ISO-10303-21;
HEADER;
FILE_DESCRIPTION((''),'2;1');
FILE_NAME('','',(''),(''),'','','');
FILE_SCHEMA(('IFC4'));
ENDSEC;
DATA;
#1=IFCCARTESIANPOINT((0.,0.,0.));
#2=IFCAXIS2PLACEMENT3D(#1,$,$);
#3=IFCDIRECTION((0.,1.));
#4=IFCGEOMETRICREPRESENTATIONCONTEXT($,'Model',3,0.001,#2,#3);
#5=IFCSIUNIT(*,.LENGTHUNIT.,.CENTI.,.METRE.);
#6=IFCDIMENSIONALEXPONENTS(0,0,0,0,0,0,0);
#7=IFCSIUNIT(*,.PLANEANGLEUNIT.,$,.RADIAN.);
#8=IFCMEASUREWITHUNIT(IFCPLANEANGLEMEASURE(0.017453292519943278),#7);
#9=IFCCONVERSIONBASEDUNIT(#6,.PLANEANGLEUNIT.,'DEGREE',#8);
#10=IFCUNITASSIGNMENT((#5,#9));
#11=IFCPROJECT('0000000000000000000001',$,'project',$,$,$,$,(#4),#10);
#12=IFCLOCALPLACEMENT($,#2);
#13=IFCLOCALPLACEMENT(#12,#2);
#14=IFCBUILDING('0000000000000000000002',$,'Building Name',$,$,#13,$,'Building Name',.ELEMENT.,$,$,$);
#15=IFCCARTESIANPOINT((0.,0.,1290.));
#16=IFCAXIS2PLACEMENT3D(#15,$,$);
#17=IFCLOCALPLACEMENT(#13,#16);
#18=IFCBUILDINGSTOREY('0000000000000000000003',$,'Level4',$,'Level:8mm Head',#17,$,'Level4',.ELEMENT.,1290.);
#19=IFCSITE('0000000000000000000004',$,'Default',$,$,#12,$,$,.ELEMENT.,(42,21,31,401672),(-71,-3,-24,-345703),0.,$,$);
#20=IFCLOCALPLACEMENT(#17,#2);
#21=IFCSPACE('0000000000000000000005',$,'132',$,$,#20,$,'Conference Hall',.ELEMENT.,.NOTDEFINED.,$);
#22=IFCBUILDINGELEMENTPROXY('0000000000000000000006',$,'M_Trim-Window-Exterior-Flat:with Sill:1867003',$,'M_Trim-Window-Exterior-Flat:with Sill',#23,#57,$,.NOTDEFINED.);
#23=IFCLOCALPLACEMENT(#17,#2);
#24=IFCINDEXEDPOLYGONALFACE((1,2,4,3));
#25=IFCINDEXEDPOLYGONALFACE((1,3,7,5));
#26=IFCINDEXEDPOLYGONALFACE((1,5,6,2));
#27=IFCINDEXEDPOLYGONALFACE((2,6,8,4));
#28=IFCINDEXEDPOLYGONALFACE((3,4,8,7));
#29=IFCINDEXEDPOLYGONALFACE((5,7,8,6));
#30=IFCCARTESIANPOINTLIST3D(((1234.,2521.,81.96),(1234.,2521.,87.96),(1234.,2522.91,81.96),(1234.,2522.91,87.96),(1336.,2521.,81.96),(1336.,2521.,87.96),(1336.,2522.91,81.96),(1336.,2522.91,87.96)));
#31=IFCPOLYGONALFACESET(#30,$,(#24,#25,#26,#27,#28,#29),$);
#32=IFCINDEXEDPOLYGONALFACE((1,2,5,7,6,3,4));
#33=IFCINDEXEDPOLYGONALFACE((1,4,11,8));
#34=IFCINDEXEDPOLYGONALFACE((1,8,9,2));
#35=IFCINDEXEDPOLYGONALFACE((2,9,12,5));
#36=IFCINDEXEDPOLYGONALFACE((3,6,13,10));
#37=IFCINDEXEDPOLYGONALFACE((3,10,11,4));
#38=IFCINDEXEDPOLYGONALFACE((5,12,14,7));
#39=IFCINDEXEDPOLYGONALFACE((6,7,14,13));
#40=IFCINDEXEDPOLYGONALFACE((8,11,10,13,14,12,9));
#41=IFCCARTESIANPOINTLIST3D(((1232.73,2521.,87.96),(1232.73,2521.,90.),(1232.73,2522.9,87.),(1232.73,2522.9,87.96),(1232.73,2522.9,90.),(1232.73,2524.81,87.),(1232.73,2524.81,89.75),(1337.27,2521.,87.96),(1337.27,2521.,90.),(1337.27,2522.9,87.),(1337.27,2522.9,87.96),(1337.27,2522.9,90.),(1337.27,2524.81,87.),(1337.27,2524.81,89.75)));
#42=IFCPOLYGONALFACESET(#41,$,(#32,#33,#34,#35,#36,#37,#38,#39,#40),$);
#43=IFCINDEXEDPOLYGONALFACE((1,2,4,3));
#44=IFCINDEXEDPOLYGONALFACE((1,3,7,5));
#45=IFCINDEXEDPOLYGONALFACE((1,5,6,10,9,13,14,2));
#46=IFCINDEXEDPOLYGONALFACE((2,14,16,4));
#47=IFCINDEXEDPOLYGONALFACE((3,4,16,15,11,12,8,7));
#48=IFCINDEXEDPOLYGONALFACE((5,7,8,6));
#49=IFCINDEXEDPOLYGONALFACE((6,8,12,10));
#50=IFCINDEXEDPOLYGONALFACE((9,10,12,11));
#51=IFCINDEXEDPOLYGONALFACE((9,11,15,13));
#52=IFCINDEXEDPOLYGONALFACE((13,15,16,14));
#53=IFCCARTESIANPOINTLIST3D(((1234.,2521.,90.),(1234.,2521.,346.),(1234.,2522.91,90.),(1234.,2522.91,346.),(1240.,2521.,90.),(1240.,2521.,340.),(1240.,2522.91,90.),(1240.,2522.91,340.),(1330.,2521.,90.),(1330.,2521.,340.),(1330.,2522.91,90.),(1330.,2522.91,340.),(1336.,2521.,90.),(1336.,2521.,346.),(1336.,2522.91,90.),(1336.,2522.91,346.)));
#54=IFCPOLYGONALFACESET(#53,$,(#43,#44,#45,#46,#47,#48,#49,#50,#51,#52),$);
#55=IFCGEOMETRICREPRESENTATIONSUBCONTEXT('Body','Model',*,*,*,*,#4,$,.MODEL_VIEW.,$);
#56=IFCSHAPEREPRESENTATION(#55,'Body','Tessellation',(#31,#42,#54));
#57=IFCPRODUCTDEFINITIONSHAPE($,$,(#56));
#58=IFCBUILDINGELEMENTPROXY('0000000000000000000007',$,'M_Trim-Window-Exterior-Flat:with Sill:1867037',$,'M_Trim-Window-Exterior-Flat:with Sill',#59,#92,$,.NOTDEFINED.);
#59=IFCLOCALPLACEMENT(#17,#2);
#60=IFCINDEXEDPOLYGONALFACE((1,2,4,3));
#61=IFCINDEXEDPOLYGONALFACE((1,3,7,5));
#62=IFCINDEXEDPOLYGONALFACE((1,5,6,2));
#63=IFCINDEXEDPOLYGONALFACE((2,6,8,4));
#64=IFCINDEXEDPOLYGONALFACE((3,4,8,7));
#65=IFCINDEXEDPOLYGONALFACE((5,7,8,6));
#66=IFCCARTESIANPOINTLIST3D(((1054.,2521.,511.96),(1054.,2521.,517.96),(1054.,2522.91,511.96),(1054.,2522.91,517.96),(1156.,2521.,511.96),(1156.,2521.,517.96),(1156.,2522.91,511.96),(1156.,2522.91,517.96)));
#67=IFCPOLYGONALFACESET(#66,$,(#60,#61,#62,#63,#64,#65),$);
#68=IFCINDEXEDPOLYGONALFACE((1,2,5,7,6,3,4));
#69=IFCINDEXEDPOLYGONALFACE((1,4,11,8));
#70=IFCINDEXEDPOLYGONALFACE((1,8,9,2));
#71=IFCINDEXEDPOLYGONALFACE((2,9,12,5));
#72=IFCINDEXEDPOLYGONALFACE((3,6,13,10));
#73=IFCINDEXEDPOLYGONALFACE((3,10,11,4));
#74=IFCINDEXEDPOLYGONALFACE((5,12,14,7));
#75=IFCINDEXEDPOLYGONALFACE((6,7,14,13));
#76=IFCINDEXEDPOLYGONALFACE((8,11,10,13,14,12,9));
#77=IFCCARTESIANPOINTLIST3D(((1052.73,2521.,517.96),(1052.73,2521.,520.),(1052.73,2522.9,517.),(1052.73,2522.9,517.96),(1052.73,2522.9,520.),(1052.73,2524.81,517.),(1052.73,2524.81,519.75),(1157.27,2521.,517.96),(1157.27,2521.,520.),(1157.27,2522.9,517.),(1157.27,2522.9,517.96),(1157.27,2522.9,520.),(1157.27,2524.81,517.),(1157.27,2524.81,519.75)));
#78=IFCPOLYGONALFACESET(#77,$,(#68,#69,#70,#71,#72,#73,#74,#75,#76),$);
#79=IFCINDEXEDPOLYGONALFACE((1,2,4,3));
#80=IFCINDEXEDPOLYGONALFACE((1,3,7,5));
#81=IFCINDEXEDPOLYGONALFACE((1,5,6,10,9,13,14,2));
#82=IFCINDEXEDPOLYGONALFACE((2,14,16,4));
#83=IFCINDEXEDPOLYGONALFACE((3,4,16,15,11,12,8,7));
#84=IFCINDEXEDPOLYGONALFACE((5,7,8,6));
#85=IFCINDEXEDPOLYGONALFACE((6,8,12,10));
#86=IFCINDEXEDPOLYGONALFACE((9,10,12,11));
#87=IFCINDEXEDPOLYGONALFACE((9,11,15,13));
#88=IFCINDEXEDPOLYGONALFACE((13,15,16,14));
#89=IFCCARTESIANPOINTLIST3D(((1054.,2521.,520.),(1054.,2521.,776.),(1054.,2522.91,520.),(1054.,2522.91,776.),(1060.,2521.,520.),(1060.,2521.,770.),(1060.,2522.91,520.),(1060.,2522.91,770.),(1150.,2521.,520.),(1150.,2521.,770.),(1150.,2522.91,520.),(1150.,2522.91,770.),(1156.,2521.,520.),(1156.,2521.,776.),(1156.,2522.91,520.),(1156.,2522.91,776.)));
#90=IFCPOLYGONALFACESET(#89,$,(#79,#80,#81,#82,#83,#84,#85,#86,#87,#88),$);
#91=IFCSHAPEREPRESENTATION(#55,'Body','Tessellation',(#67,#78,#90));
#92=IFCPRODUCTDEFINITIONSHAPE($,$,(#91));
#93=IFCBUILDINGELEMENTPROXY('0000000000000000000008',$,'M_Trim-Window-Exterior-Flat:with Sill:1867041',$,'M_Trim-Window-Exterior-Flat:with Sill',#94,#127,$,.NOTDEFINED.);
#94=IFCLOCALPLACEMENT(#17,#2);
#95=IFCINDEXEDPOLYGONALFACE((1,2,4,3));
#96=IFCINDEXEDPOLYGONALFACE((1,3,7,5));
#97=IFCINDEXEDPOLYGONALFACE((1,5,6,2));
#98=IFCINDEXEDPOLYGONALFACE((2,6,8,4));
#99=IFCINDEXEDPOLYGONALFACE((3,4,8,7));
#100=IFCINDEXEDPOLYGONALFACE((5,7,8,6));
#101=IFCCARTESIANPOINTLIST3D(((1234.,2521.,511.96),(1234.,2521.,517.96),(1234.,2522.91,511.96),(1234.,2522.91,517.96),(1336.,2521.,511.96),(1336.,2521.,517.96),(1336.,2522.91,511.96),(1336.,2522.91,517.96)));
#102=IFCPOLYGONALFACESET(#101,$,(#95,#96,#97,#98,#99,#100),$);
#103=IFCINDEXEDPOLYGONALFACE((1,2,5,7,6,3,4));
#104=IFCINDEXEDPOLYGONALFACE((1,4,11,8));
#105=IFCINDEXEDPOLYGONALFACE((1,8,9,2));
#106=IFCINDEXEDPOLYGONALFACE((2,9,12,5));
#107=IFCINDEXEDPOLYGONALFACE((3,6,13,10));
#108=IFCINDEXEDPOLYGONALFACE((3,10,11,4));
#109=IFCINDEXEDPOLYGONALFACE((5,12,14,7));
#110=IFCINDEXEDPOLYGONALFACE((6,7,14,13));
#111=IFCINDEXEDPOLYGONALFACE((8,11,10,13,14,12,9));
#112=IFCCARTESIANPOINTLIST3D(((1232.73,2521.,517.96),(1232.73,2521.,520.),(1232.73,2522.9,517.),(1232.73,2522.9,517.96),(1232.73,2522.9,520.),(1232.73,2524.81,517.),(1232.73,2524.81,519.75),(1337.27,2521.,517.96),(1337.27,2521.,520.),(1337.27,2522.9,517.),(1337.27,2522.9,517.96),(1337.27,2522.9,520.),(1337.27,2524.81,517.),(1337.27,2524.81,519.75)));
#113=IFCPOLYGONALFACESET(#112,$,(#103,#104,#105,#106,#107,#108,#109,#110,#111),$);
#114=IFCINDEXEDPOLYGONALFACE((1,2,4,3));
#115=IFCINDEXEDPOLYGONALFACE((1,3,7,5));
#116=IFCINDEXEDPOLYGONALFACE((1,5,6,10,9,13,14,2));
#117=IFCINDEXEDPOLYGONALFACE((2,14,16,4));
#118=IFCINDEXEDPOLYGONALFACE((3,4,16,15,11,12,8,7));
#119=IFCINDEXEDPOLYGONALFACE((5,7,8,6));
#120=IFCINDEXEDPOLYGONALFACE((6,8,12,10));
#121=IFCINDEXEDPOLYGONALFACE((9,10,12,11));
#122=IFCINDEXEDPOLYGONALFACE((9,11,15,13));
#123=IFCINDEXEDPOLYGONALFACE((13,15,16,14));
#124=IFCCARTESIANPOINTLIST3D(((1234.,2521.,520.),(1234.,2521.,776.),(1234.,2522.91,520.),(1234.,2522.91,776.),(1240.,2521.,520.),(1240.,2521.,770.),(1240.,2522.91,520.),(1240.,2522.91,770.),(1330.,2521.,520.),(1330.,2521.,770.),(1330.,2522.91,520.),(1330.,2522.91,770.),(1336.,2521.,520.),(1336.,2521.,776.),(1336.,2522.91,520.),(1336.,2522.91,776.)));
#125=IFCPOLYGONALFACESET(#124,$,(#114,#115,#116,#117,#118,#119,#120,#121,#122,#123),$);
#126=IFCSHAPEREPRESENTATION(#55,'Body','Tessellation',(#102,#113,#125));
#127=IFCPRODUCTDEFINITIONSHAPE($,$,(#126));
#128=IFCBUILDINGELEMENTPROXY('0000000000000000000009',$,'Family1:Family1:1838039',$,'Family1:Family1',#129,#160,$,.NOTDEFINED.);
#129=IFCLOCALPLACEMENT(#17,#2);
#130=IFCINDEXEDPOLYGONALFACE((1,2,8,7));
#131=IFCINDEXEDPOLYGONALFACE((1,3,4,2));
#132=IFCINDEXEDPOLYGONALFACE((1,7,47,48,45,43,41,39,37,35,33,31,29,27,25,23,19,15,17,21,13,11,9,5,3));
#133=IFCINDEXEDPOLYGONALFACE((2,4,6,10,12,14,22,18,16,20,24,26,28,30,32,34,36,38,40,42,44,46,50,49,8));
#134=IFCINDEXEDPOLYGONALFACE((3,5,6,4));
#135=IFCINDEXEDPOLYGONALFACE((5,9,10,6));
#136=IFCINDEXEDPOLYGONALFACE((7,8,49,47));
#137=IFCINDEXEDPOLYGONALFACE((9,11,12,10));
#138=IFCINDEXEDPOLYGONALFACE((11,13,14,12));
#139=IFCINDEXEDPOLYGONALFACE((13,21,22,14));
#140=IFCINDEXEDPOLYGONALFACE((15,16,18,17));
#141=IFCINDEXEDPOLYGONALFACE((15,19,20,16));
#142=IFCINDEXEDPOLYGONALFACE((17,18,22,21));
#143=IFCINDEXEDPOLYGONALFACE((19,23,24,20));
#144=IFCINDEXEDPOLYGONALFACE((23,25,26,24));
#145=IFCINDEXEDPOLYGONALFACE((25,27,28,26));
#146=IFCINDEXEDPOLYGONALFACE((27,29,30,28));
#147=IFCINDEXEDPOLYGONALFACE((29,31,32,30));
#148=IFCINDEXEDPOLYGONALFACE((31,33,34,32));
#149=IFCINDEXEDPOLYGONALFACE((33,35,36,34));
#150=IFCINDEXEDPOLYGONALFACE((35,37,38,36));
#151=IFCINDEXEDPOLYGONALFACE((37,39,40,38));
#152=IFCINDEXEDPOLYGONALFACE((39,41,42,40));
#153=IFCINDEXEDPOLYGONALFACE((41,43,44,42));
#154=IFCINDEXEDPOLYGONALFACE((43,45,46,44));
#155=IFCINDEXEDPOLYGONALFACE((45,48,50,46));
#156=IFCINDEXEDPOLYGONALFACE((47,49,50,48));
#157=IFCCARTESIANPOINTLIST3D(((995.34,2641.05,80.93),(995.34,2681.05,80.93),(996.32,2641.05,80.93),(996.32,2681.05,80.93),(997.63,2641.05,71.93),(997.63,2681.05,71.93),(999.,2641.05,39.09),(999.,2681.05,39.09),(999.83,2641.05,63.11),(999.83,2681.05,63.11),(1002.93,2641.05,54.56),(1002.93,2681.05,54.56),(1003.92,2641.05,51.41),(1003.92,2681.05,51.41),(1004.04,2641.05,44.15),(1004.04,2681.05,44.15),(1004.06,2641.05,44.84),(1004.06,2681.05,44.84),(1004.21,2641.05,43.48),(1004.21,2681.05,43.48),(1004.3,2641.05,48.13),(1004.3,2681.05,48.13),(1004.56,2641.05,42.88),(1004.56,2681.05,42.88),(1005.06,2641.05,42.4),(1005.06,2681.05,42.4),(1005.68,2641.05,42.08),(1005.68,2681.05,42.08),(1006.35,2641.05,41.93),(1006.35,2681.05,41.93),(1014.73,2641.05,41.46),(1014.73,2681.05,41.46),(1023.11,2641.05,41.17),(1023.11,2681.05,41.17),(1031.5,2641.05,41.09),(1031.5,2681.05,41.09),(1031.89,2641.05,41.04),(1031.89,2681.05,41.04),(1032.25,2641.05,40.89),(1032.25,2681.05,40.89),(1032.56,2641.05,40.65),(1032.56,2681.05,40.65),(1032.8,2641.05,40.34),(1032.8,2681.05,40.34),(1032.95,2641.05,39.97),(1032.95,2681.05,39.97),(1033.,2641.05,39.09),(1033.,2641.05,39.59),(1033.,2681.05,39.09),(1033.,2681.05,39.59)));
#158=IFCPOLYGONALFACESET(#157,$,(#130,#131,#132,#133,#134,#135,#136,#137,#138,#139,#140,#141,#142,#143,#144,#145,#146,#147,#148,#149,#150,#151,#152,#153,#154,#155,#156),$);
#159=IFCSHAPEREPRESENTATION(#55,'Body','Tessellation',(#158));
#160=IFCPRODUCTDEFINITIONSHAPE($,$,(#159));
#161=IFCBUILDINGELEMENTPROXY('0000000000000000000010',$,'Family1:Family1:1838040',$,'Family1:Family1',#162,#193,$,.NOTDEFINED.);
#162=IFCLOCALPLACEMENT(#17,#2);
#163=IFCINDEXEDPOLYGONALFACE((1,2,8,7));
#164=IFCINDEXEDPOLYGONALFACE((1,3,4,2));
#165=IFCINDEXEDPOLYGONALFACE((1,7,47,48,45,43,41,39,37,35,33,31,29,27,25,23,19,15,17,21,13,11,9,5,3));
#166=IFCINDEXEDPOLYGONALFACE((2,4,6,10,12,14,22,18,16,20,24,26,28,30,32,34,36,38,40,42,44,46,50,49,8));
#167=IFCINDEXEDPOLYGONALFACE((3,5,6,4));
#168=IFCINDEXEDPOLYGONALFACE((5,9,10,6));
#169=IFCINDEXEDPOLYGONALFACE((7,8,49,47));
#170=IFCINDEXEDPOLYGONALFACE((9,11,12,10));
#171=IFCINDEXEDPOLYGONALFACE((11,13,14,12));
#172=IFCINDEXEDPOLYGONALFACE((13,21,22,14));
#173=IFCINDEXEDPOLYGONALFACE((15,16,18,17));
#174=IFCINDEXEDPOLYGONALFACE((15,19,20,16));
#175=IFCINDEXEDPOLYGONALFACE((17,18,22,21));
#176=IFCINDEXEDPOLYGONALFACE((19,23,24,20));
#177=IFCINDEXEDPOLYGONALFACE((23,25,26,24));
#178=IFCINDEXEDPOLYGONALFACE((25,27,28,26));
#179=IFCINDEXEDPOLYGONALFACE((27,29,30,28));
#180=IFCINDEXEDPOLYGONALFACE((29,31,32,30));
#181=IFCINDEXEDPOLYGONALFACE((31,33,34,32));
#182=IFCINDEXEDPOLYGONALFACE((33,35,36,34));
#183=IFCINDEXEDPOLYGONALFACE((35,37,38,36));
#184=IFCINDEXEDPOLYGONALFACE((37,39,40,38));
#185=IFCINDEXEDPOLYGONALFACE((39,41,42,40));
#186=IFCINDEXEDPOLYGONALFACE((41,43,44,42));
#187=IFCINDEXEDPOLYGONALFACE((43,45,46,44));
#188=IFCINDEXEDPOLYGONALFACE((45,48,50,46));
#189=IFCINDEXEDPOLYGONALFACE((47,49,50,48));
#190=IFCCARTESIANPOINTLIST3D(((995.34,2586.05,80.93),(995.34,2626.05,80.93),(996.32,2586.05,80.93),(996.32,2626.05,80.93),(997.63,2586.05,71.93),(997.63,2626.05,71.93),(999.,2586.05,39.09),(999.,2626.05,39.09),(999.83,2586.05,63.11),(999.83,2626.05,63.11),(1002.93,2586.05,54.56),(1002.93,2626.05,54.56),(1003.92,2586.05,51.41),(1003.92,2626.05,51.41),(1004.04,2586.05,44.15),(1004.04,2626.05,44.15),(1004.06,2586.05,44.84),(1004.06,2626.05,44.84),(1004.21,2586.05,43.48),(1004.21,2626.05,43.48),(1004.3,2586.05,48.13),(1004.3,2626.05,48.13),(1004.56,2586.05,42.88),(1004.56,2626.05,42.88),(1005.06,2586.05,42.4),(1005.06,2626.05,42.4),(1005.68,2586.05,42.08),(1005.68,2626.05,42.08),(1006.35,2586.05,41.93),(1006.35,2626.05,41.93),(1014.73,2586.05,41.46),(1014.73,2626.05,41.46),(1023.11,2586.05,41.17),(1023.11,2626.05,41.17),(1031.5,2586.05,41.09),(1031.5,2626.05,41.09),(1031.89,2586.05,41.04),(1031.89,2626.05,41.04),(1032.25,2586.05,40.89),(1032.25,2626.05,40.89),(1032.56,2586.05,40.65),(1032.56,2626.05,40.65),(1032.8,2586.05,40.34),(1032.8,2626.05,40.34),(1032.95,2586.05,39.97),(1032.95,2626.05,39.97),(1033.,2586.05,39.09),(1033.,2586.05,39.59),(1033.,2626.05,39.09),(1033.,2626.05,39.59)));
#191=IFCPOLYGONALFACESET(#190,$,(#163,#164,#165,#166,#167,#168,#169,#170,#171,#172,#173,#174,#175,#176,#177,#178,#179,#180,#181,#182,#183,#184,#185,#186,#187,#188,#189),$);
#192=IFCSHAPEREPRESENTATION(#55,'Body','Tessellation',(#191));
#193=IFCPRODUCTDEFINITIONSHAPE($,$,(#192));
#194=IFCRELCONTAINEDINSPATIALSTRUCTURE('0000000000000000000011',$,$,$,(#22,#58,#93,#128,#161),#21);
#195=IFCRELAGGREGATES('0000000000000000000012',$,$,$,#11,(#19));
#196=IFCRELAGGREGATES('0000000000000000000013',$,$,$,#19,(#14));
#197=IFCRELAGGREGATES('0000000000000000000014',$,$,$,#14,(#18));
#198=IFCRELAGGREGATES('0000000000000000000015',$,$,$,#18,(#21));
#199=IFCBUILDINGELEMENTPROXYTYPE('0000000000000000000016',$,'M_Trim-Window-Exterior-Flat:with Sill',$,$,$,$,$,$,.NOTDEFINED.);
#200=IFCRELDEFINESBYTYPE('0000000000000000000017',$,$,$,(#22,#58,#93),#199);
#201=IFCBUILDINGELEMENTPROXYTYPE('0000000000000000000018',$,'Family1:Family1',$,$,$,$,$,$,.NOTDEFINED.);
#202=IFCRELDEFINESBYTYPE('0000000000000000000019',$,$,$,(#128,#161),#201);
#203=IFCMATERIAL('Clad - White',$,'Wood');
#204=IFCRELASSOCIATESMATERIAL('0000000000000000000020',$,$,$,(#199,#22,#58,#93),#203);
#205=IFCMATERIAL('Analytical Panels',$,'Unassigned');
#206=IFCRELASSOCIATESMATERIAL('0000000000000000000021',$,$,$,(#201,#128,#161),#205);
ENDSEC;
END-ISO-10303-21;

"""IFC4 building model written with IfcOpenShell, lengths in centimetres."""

from ifc_helpers import new_model, entity, si_unit, converted_unit, direction, frame, origin, place, context, subcontext, project, spatial, line, arc, indexed_curve, outline, extrude, source, transform, mapped, material, type_object, type_shapes, element, save


model = new_model("IFC4")

# Units and contexts
model_context = context("Model", 3, precision=0.001, world=origin(), true_north=direction((0.0, 1.0)))
body_context = subcontext(model_context, "Body", "Model", "MODEL_VIEW")
ifc_project = project(units=[si_unit("LENGTHUNIT", "METRE", prefix="CENTI"), converted_unit("PLANEANGLEUNIT", "DEGREE", entity("IfcPlaneAngleMeasure", 0.017453292519943278), si_unit("PLANEANGLEUNIT", "RADIAN"), dimensions=[0, 0, 0, 0, 0, 0, 0])], contexts=[model_context])

# Site, building, storey
site_placement = place(None, origin())
site = spatial("IfcSite", under=ifc_project, at=site_placement, Name="Default", CompositionType="ELEMENT", RefLatitude=(42, 21, 31, 401672), RefLongitude=(-71, -3, -24, -345703), RefElevation=0.0)
building_placement = place(site_placement, origin())
building = spatial("IfcBuilding", under=site, at=building_placement, Name="Building Name", LongName="Building Name", CompositionType="ELEMENT")
storey_placement = place(building_placement, frame((0.0, 0.0, 1290.0)))
storey = spatial("IfcBuildingStorey", under=building, at=storey_placement, Name="Level4", ObjectType="Level:8mm Head", LongName="Level4", CompositionType="ELEMENT", Elevation=1290.0)

# Shared definitions
space_placement = place(storey_placement, origin())
space = spatial("IfcSpace", under=storey, at=space_placement, Name="132", LongName="Conference Hall", CompositionType="ELEMENT", PredefinedType="NOTDEFINED")

# Building element proxies
ifc_material_1 = material(Name="Clad - White", Category="Wood")
building_element_proxy_type_1 = type_object("IfcBuildingElementProxyType", Name="M_Trim-Window-Exterior-Flat:with Sill", PredefinedType="NOTDEFINED", material=ifc_material_1)
shared_shape_1 = source(origin(), body_context, "Body", "SweptSolid", [
    extrude(outline(indexed_curve([(-51.0, -3.0), (51.0, -3.0), (51.0, 3.0), (-51.0, 3.0), (-51.0, -3.0)], self_intersect=False)), frame((0.0, -255.04, 0.0), z_axis=(0.0, 0.0, 1.0), x_axis=(-1.0, 0.0, 0.0)), (0.0, 0.0, 1.0), 1.9),
    extrude(outline(indexed_curve([(-1.9, -1.52), (0.0, -1.52), (0.0, -0.57), (1.9, -0.57), (1.9, 1.48), (0.0, 1.48), (-1.9, 1.23), (-1.9, -1.52)], self_intersect=False)), frame((-52.27, -251.48, 1.9), z_axis=(1.0, 0.0, 0.0), x_axis=(0.0, 0.0, -1.0)), (0.0, 0.0, 1.0), 104.54),
    extrude(outline(indexed_curve([(-129.5, -51.0), (126.5, -51.0), (126.5, -45.0), (-123.5, -45.0), (-123.5, 45.0), (126.5, 45.0), (126.5, 51.0), (-129.5, 51.0), (-129.5, -51.0)], self_intersect=False)), frame((0.0, -123.5, 0.0), z_axis=(0.0, 0.0, 1.0), x_axis=(0.0, -1.0, 0.0)), (0.0, 0.0, 1.0), 1.9),
])
type_shapes(building_element_proxy_type_1, [shared_shape_1])
for number, where, z_axis, x_axis, name in (
    (1, (1285.0, 2521.0, 340.0), (0.0, 1.0, 0.0), (-1.0, 0.0, 0.0), "M_Trim-Window-Exterior-Flat:with Sill:1867003"),
    (2, (1105.0, 2521.0, 770.0), (0.0, 1.0, 0.0), (-1.0, 0.0, 0.0), "M_Trim-Window-Exterior-Flat:with Sill:1867037"),
    (3, (1285.0, 2521.0, 770.0), (0.0, 1.0, 0.0), (-1.0, 0.0, 0.0), "M_Trim-Window-Exterior-Flat:with Sill:1867041"),
):
    element("IfcBuildingElementProxy", number, at=place(space_placement, frame(where, z_axis=z_axis, x_axis=x_axis)), inside=space, type_object=building_element_proxy_type_1, material=ifc_material_1, Name=name, ObjectType="M_Trim-Window-Exterior-Flat:with Sill", PredefinedType="NOTDEFINED", context=body_context, shape_type="MappedRepresentation", body=[
        mapped(shared_shape_1, transform((0.0, 0.0, 0.0), scale=1.0)),
    ])
ifc_material_2 = material(Name="Analytical Panels", Category="Unassigned")
building_element_proxy_type_2 = type_object("IfcBuildingElementProxyType", Name="Family1:Family1", PredefinedType="NOTDEFINED", material=ifc_material_2)
shared_shape_2 = source(origin(), body_context, "Body", "SweptSolid", [
    extrude(outline(indexed_curve([(-11.13, -13.3), (30.87, -13.3), (30.78, -12.32), (17.19, -11.21), (3.93, -8.04), (-0.94, -7.2), (-5.84, -7.76), (-7.84, -7.43), (-8.94, -5.73), (-10.68, 6.74), (-11.98, 19.25), (-12.51, 20.27), (-13.6, 20.61), (-14.09, 20.57)], segments=[line(1, 2, 3), arc(3, 4, 5), arc(5, 6, 7), arc(7, 8, 9), arc(9, 10, 11), arc(11, 12, 13), line(13, 14, 1)], self_intersect=False)), frame((-20.0, 6.72, 12.25), z_axis=(1.0, 0.0, 0.0), x_axis=(0.0, 0.087156, 0.996195)), (0.0, 0.0, 1.0), 40.0),
])
type_shapes(building_element_proxy_type_2, [shared_shape_2])
for number, where, z_axis, x_axis, name in (
    (4, (1018.0, 2661.05, 39.09), (0.0, 0.0, 1.0), (0.0, 1.0, 0.0), "Family1:Family1:1838039"),
    (5, (1018.0, 2606.05, 39.09), (0.0, 0.0, 1.0), (0.0, 1.0, 0.0), "Family1:Family1:1838040"),
):
    element("IfcBuildingElementProxy", number, at=place(space_placement, frame(where, z_axis=z_axis, x_axis=x_axis)), inside=space, type_object=building_element_proxy_type_2, material=ifc_material_2, Name=name, ObjectType="Family1:Family1", PredefinedType="NOTDEFINED", context=body_context, shape_type="MappedRepresentation", body=[
        mapped(shared_shape_2, transform((0.0, 0.0, 0.0), scale=1.0)),
    ])

save(model, "model.ifc")
